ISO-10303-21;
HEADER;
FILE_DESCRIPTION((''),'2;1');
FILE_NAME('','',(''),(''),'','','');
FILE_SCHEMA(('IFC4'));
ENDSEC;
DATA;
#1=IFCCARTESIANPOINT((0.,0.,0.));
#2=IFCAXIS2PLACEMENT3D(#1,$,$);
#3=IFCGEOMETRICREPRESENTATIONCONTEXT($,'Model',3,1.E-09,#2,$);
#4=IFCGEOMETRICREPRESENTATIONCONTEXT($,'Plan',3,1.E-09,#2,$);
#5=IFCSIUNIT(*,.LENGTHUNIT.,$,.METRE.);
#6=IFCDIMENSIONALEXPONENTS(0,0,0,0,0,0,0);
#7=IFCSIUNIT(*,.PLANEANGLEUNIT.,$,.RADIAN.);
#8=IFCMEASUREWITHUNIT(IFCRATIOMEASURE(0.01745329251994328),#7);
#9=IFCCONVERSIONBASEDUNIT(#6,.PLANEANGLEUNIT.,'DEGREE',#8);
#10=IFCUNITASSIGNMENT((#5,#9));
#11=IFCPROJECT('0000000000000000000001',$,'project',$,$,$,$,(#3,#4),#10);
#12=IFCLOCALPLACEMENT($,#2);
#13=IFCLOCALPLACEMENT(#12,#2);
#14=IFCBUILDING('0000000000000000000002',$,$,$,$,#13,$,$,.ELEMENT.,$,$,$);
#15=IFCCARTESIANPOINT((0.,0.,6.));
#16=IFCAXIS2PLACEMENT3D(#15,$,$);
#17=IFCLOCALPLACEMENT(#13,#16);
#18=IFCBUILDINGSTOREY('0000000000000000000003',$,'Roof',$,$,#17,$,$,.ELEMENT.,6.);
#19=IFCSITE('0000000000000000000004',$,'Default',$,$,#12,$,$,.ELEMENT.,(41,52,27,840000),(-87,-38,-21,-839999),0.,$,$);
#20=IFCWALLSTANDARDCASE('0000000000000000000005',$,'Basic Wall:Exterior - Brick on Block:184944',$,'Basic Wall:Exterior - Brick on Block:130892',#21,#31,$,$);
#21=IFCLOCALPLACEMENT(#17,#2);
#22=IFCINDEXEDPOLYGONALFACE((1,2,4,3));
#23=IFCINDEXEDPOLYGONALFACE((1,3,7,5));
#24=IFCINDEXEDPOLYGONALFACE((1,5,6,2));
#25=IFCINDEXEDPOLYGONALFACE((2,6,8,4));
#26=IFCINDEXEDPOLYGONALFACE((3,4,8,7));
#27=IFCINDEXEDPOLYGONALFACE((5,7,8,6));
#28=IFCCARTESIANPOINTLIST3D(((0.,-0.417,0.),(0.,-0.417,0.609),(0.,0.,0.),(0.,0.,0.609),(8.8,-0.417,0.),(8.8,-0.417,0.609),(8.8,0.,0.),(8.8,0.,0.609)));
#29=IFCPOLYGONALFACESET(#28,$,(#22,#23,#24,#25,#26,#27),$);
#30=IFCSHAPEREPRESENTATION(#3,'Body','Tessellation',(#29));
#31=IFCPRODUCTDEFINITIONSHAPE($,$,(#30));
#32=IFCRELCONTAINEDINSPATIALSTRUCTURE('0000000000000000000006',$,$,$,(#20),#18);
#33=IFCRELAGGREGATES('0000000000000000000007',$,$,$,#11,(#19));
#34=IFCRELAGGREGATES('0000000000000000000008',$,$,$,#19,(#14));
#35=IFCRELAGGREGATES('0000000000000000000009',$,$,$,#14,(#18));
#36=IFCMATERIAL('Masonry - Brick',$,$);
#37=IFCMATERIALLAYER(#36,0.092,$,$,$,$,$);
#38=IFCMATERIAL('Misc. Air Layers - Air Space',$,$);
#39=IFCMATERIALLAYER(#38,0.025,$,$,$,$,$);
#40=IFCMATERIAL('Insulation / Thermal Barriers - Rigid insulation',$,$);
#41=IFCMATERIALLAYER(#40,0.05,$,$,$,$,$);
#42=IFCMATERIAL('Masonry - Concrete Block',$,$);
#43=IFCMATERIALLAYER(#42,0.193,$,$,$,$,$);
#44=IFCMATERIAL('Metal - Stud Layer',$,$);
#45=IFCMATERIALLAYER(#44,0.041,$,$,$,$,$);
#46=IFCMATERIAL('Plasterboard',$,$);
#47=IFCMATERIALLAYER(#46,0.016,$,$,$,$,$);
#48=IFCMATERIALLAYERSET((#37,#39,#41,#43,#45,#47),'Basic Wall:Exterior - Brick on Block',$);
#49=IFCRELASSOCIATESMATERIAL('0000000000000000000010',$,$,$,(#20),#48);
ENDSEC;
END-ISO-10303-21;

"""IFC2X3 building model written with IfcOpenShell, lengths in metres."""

from ifc_helpers import new_model, entity, si_unit, converted_unit, frame, frame_2d, origin, place, context, project, spatial, rectangle, extrude, material, layer, layer_set, layer_usage, element, save


model = new_model("IFC2X3")

# Units and contexts
model_context = context("Model", 3, precision=1e-09, world=origin())
plan_context = context("Plan", 3, precision=1e-09, world=origin())
ifc_project = project(units=[si_unit("LENGTHUNIT", "METRE"), converted_unit("PLANEANGLEUNIT", "DEGREE", entity("IfcRatioMeasure", 0.01745329251994328), si_unit("PLANEANGLEUNIT", "RADIAN"), dimensions=[0, 0, 0, 0, 0, 0, 0])], contexts=[model_context, plan_context])

# Site, building, storey
site_placement = place(None, origin())
site = spatial("IfcSite", under=ifc_project, at=site_placement, Name="Default", CompositionType="ELEMENT", RefLatitude=(41, 52, 27, 840000), RefLongitude=(-87, -38, -21, -839999), RefElevation=0.0)
building_placement = place(site_placement, origin())
building = spatial("IfcBuilding", under=site, at=building_placement, CompositionType="ELEMENT")
storey_placement = place(building_placement, frame((0.0, 0.0, 6.0)))
storey = spatial("IfcBuildingStorey", under=building, at=storey_placement, Name="Roof", CompositionType="ELEMENT", Elevation=6.0)

# Wall
ifc_material_1 = material(Name="Masonry - Brick")
ifc_layer_1 = layer(ifc_material_1, 0.092)
ifc_material_2 = material(Name="Misc. Air Layers - Air Space")
ifc_layer_2 = layer(ifc_material_2, 0.025)
ifc_material_3 = material(Name="Insulation / Thermal Barriers - Rigid insulation")
ifc_layer_3 = layer(ifc_material_3, 0.05)
ifc_material_4 = material(Name="Masonry - Concrete Block")
ifc_layer_4 = layer(ifc_material_4, 0.193)
ifc_material_5 = material(Name="Metal - Stud Layer")
ifc_layer_5 = layer(ifc_material_5, 0.041)
ifc_material_6 = material(Name="Plasterboard")
ifc_layer_6 = layer(ifc_material_6, 0.016)
ifc_layer_set = layer_set([ifc_layer_1, ifc_layer_2, ifc_layer_3, ifc_layer_4, ifc_layer_5, ifc_layer_6], Name="Basic Wall:Exterior - Brick on Block")
ifc_layer_usage = layer_usage(ifc_layer_set, "AXIS2", "NEGATIVE", 0.2085)
wall_placement = place(storey_placement, frame((0.0, -0.2085, 0.0)))
element("IfcWallStandardCase", 1, at=wall_placement, inside=storey, material=ifc_layer_usage, Name="Basic Wall:Exterior - Brick on Block:184944", ObjectType="Basic Wall:Exterior - Brick on Block:130892", context=model_context, shape_type="SweptSolid", body=[
    extrude(rectangle(XDim=8.8, YDim=0.417, at=frame_2d((4.4, 0.0), x_axis=(-1.0, 0.0))), origin(), (0.0, 0.0, 1.0), 0.609),
])

save(model, "model.ifc")
